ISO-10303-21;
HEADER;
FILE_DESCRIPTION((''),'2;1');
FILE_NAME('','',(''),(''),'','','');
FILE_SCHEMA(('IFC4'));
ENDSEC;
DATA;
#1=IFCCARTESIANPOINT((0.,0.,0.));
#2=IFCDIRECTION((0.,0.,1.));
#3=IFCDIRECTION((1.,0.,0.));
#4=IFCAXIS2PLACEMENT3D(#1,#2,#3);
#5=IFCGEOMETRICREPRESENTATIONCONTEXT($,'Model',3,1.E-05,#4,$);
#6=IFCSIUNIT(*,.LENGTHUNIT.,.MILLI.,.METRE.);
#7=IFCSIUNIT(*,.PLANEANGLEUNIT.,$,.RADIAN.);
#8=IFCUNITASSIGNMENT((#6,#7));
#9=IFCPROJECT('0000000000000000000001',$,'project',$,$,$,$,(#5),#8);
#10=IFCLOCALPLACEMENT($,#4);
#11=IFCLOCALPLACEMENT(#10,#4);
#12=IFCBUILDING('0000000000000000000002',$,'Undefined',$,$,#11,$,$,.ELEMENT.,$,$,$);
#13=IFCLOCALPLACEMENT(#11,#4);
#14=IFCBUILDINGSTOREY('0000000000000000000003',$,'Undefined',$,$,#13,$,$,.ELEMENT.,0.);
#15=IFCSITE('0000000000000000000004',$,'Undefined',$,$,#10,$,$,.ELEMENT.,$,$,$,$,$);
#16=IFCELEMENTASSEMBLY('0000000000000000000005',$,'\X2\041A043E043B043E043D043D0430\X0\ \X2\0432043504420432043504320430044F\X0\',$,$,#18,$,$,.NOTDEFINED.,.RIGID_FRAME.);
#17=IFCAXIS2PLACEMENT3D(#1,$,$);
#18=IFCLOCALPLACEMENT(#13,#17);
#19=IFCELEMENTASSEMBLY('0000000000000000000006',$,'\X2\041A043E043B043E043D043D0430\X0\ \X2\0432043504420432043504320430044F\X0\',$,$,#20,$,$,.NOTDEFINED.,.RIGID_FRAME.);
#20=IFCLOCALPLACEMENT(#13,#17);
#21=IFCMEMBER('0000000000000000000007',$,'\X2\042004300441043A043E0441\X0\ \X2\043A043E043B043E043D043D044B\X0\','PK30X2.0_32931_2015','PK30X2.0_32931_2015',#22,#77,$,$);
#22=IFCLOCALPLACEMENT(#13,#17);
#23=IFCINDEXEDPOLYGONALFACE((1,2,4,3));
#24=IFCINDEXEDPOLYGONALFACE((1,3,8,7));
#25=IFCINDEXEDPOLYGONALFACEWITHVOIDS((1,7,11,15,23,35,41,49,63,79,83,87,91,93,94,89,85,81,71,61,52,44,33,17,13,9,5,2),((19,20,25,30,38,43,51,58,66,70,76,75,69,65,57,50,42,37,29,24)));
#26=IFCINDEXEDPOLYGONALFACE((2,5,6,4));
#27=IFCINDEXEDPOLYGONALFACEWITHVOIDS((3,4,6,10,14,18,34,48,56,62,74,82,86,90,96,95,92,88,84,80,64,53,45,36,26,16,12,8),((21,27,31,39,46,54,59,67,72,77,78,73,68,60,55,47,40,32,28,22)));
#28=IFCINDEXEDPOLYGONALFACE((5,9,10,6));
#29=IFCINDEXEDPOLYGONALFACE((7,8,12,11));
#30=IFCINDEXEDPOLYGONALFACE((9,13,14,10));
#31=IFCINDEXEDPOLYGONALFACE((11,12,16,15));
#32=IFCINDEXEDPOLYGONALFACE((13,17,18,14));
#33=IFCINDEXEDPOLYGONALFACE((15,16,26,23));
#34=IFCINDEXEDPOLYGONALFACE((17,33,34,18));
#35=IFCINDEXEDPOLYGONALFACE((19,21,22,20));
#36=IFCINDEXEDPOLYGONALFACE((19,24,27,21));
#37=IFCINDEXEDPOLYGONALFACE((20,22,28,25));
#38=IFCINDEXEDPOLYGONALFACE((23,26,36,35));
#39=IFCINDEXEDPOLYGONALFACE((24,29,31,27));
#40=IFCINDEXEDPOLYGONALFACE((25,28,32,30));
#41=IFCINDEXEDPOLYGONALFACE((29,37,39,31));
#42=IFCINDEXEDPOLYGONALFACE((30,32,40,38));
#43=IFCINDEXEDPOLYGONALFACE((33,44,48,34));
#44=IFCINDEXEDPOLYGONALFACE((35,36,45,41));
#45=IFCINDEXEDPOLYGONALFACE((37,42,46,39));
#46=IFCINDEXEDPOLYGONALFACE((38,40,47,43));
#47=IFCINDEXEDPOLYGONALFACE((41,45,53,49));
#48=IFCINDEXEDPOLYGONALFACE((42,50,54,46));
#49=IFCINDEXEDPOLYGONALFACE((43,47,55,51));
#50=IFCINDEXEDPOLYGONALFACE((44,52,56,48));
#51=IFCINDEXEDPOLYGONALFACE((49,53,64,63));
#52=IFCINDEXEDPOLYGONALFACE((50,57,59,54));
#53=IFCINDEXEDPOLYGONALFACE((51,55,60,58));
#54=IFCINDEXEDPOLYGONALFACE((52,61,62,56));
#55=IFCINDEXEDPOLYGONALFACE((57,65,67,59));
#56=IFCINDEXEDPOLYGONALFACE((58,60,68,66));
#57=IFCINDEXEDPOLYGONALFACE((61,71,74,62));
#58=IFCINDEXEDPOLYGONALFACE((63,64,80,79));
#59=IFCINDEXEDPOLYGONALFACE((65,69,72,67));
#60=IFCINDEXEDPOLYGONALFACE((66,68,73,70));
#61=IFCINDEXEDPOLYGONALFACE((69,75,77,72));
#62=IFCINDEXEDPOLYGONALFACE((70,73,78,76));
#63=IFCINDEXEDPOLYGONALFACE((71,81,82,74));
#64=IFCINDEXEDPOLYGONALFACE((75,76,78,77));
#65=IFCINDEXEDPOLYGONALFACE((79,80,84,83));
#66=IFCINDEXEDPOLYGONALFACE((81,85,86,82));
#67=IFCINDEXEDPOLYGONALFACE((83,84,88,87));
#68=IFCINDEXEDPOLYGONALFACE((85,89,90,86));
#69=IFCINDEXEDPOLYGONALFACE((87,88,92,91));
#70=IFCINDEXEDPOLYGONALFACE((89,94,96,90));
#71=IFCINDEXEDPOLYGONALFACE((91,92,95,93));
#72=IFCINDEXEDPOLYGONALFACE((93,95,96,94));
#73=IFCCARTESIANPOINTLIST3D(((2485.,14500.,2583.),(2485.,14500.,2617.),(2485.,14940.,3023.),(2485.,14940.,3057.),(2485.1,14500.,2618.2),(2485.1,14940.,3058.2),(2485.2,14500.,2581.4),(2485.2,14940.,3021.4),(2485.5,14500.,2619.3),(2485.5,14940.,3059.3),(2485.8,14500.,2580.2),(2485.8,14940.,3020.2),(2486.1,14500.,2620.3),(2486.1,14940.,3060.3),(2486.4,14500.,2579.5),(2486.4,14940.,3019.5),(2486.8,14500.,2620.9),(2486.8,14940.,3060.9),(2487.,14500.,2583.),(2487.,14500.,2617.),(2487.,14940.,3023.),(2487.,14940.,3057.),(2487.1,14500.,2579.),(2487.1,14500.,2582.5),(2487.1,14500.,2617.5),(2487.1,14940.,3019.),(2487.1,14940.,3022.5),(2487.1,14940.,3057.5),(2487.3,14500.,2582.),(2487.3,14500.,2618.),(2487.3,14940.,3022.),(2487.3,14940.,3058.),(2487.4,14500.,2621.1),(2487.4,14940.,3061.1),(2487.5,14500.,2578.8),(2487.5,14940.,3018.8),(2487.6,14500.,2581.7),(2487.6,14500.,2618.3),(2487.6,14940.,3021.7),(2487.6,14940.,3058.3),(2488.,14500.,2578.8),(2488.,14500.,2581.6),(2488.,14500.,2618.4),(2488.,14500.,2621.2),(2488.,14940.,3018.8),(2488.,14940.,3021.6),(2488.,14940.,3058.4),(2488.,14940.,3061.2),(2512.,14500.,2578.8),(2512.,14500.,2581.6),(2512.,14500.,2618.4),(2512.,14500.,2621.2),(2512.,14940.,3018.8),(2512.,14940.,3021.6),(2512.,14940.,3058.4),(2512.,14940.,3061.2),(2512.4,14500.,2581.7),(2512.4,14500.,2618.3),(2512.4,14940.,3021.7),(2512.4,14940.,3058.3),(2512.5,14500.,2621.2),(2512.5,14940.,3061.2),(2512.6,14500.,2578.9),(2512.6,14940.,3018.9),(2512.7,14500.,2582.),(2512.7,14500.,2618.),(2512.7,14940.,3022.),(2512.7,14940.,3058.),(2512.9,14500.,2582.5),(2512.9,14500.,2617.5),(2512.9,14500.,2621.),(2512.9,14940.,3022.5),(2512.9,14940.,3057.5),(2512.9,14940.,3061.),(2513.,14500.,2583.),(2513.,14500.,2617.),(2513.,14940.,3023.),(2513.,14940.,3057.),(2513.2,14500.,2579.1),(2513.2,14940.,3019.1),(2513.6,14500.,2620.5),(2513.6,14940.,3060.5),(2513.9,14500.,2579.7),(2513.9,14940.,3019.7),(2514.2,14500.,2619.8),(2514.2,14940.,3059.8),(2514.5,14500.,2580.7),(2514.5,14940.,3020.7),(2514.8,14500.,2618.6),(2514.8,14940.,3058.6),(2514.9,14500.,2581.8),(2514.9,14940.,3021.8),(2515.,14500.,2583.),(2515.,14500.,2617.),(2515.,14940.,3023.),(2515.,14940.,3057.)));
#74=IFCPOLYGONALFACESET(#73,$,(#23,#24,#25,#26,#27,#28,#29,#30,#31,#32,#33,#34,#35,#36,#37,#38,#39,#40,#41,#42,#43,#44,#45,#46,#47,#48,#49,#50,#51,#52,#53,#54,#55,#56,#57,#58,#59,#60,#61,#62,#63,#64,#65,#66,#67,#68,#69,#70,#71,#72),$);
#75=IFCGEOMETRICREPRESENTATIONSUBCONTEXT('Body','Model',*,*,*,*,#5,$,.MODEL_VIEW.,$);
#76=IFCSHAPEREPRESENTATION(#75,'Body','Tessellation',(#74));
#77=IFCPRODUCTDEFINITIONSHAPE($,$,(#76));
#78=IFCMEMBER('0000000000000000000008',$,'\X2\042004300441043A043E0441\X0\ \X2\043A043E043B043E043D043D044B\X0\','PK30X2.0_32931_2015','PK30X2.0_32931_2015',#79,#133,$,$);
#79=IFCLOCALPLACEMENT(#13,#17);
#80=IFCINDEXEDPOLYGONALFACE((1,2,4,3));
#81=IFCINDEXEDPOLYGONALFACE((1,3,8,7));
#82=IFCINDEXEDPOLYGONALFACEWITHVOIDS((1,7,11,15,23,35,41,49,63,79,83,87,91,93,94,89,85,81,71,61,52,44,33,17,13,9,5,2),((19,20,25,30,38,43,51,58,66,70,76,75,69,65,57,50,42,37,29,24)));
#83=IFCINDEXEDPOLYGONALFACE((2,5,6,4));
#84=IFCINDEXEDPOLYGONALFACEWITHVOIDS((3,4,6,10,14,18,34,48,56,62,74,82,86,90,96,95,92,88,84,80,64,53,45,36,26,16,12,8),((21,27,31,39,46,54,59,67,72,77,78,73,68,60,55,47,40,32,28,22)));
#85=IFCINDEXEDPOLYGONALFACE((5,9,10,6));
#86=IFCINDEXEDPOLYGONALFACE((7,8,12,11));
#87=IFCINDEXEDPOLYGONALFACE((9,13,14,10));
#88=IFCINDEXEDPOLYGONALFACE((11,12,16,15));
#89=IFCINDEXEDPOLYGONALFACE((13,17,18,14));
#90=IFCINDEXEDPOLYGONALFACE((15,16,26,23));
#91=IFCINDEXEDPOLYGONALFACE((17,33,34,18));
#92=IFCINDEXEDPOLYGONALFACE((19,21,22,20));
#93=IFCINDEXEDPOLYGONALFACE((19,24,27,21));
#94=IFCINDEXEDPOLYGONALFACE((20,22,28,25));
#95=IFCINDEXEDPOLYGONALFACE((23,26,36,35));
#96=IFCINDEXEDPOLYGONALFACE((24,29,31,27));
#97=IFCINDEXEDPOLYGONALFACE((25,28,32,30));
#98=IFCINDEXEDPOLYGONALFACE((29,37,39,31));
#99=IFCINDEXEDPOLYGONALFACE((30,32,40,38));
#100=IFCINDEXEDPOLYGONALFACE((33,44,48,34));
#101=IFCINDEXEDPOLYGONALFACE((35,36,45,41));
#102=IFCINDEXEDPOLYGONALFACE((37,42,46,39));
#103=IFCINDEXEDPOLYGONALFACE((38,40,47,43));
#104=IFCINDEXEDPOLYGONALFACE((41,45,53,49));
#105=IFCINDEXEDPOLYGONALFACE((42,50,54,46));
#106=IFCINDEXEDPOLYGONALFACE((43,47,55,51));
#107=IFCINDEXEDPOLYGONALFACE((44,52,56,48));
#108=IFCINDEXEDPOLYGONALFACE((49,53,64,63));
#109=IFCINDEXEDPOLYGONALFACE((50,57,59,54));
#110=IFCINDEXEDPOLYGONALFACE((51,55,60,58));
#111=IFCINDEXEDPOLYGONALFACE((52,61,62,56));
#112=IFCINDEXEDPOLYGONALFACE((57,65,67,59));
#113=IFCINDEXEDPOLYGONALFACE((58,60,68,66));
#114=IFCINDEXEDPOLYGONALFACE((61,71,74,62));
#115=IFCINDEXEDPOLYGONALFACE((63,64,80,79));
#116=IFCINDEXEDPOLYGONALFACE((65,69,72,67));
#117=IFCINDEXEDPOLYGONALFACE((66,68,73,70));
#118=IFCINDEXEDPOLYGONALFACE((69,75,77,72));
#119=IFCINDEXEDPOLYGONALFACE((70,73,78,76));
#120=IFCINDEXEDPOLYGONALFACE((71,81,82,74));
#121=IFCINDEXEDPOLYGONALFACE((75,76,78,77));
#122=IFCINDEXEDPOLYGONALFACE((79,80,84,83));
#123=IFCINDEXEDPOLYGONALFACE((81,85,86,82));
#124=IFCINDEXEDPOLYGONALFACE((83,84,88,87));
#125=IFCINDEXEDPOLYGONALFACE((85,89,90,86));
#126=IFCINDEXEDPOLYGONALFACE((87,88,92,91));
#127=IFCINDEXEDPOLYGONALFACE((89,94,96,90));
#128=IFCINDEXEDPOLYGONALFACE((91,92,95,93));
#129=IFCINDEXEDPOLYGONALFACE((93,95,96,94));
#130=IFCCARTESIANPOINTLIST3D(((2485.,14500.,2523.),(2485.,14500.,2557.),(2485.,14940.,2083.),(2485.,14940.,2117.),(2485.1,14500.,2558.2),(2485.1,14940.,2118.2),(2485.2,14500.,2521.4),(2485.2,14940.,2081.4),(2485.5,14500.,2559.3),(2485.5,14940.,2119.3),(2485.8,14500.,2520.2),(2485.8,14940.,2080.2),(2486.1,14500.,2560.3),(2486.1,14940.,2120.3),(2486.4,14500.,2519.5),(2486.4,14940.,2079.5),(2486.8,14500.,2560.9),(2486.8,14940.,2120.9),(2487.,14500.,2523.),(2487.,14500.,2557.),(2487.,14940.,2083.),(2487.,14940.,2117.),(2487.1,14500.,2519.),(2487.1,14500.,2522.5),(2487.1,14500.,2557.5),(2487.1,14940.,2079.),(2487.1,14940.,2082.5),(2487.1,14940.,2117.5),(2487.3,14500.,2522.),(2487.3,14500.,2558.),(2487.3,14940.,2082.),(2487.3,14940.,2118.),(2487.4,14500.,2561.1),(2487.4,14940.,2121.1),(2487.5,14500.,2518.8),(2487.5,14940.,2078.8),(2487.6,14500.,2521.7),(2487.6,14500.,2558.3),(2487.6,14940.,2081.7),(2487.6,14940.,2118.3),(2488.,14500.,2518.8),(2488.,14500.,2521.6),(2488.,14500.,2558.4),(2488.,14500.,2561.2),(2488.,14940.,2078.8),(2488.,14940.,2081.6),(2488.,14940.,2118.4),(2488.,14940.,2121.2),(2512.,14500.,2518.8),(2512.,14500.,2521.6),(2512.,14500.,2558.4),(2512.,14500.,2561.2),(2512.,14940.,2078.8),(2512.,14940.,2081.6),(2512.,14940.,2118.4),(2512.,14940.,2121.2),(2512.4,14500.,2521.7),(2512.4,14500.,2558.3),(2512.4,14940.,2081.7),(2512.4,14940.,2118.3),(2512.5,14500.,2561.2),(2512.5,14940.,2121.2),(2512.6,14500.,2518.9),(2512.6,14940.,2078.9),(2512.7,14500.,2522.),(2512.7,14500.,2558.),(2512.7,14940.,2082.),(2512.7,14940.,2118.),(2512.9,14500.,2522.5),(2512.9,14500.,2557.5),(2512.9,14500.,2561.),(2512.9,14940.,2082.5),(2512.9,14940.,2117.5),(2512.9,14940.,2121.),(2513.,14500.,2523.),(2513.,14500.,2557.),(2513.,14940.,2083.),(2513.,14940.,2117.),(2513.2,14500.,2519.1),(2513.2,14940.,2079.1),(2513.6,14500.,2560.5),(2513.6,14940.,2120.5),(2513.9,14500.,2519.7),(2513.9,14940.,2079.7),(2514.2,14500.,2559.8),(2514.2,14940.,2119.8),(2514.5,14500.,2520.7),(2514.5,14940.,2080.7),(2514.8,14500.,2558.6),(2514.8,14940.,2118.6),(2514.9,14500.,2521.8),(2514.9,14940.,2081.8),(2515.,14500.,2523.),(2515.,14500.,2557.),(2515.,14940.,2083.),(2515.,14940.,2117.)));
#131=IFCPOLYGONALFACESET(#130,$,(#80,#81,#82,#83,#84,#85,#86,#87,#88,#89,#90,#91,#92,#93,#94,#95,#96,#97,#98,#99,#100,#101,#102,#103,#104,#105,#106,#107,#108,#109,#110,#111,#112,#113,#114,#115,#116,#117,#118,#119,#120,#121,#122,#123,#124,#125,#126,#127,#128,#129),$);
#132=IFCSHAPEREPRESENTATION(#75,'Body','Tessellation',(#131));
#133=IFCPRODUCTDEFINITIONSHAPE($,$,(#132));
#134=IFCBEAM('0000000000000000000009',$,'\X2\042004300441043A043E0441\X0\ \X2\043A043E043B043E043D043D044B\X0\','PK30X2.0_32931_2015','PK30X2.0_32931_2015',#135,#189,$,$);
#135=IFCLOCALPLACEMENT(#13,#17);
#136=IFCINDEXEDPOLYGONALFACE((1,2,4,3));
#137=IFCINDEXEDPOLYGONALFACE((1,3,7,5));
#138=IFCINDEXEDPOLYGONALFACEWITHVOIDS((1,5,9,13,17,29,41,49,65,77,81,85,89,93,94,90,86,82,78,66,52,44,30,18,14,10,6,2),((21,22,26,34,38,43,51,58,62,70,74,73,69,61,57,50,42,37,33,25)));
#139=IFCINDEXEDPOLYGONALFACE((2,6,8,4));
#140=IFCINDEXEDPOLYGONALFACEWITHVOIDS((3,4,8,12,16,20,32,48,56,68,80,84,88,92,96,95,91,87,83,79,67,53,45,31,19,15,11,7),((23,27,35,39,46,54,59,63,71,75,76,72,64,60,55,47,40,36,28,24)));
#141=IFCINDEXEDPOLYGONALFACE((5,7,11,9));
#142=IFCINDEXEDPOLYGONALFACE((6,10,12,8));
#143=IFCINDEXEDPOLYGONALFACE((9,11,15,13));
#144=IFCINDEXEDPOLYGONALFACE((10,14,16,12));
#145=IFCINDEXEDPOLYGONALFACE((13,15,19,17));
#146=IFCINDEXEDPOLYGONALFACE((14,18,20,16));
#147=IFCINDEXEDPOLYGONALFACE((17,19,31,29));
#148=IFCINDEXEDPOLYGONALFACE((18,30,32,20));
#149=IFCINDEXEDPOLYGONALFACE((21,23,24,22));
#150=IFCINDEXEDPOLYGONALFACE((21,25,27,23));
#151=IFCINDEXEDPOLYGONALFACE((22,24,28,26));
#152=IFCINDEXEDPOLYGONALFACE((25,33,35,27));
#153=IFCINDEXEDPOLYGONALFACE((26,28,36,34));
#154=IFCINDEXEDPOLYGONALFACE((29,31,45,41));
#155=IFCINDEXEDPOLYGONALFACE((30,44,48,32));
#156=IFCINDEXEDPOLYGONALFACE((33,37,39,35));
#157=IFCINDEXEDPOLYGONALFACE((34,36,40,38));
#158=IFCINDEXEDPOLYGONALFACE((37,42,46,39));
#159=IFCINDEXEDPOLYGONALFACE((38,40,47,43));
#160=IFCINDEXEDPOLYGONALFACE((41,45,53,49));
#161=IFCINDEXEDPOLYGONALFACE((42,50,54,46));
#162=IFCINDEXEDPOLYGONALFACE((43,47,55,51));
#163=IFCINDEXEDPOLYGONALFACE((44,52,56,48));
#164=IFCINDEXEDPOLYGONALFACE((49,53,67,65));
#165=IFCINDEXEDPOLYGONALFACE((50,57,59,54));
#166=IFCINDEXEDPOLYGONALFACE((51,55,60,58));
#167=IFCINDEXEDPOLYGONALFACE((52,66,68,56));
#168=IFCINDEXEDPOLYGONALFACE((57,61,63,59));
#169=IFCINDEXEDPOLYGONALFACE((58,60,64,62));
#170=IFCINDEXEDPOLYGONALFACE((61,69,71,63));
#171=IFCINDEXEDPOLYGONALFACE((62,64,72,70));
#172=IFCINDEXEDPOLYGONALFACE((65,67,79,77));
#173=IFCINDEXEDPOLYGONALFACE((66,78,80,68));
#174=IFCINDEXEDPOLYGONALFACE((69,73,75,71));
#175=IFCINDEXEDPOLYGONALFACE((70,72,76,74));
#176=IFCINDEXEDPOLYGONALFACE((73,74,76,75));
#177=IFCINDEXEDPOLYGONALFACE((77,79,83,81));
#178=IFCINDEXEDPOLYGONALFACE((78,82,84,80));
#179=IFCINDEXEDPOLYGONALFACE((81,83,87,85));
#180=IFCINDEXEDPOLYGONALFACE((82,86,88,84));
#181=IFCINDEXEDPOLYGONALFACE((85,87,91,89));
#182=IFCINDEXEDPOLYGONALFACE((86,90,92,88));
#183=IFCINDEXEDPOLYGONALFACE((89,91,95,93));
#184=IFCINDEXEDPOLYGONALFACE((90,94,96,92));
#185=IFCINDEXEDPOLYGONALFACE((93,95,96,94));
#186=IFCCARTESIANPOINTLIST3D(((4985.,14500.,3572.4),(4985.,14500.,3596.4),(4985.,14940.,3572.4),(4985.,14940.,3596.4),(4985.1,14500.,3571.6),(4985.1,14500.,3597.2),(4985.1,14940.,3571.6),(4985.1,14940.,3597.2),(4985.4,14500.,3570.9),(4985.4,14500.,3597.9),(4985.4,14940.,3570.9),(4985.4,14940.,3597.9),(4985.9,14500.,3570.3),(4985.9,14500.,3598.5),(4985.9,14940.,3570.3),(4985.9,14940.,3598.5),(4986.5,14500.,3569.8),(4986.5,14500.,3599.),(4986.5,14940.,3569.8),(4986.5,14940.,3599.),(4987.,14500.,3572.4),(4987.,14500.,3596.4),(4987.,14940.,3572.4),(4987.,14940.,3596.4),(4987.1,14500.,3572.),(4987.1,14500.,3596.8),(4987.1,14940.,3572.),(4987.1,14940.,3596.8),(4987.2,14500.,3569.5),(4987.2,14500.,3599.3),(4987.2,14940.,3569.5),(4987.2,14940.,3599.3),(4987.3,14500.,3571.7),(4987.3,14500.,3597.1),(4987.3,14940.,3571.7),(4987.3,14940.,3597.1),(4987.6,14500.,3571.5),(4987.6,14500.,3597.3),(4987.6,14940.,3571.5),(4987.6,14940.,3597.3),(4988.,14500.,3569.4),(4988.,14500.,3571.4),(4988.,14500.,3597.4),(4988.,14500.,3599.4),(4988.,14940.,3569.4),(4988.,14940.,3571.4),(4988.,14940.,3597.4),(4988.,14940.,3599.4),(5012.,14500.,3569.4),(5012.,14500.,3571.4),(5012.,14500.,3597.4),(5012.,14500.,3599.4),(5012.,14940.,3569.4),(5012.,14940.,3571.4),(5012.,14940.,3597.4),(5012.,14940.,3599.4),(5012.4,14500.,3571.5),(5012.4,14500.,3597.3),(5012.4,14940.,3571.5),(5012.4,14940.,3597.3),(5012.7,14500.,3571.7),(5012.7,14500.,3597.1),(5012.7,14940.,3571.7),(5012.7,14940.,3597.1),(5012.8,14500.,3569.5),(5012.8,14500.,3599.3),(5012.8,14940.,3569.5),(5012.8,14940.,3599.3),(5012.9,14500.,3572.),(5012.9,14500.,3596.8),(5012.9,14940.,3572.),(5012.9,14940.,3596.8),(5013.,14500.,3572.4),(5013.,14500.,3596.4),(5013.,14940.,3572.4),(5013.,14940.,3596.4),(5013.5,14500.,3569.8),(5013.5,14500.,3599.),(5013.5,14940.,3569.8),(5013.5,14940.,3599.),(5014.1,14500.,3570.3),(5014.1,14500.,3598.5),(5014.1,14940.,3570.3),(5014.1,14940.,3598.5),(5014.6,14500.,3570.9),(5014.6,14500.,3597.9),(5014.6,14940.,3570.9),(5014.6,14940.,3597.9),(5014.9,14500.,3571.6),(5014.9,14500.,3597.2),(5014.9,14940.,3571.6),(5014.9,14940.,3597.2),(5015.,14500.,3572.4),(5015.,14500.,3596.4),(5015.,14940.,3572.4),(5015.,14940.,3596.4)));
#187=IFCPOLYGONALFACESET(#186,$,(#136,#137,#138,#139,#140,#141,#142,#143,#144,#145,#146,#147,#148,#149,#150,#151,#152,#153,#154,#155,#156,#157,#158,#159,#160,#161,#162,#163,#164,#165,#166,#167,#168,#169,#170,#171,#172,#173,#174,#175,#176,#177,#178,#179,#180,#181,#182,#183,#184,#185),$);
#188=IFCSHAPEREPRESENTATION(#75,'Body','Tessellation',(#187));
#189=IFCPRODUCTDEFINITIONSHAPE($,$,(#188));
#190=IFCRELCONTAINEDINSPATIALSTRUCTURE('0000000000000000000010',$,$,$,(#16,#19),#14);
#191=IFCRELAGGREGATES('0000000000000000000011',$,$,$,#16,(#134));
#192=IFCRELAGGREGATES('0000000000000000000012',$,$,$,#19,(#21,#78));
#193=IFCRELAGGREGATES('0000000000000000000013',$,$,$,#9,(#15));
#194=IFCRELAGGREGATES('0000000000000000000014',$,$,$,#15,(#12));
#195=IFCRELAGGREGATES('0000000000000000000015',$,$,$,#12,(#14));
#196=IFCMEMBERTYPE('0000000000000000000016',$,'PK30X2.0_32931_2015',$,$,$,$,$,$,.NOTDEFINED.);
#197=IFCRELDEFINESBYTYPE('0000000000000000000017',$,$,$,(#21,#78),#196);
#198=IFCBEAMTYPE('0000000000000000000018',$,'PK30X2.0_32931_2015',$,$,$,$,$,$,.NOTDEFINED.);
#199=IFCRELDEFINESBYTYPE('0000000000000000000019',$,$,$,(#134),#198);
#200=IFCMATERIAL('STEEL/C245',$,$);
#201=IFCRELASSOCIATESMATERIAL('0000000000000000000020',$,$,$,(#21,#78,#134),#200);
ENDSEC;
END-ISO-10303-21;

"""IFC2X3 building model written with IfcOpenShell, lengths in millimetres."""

from ifc_helpers import new_model, si_unit, frame, origin_with_axes, origin_2d_with_axis, place, context, subcontext, project, spatial, hollow_rectangle, extrude, clip, halfspace, material, type_object, element, aggregate, save


model = new_model("IFC2X3")

# Units and contexts
model_context = context("Model", 3, precision=1e-05, world=origin_with_axes())
body_context = subcontext(model_context, "Body", "Model", "MODEL_VIEW")
ifc_project = project(units=[si_unit("LENGTHUNIT", "METRE", prefix="MILLI"), si_unit("PLANEANGLEUNIT", "RADIAN")], contexts=[model_context])

# Site, building, storey
site_placement = place(None, origin_with_axes())
site = spatial("IfcSite", under=ifc_project, at=site_placement, Name="Undefined", CompositionType="ELEMENT")
building_placement = place(site_placement, origin_with_axes())
building = spatial("IfcBuilding", under=site, at=building_placement, Name="Undefined", CompositionType="ELEMENT")
storey_placement = place(building_placement, origin_with_axes())
storey = spatial("IfcBuildingStorey", under=building, at=storey_placement, Name="Undefined", CompositionType="ELEMENT", Elevation=0.0)

# Shared definitions
ifc_material_1 = material(Name="STEEL/C245")

# Element assemblies, members
assembly_1_placement = place(storey_placement, origin_with_axes())
assembly_1 = element("IfcElementAssembly", 1, at=assembly_1_placement, inside=storey, Name="Колонна ветвевая", AssemblyPlace="NOTDEFINED", PredefinedType="RIGID_FRAME")
member_type_1 = type_object("IfcMemberType", Name="PK30X2.0_32931_2015", PredefinedType="NOTDEFINED")
assembly_2_placement = place(storey_placement, origin_with_axes())
assembly_2 = element("IfcElementAssembly", 2, at=assembly_2_placement, inside=storey, Name="Колонна ветвевая", AssemblyPlace="NOTDEFINED", PredefinedType="RIGID_FRAME")
member_1_placement = place(assembly_2_placement, frame((2500.0, 14470.0, 2570.0), z_axis=(0.0, -0.707107, 0.707107), x_axis=(0.0, 0.707107, 0.707107)))
member_1 = element("IfcMember", 3, at=member_1_placement, type_object=member_type_1, material=ifc_material_1, Name="Раскос колонны", Description="PK30X2.0_32931_2015", ObjectType="PK30X2.0_32931_2015", context=body_context, shape_type="Clipping", body=[
    clip(clip(extrude(hollow_rectangle(XDim=30.0, YDim=30.0, WallThickness=2.0, InnerFilletRadius=1.0, OuterFilletRadius=3.0, at=origin_2d_with_axis()), frame((695.0, 0.0, 0.0), z_axis=(-1.0, 0.0, 0.0), x_axis=(0.0, -1.0, 0.0)), (0.0, 0.0, 1.0), 682.9), halfspace(frame((629.0, 0.0, -35.7), z_axis=(-0.707107, 0.0, 0.707107), x_axis=(0.707107, 0.0, 0.707107)), True)), halfspace(frame((65.2, 0.0, 22.8), z_axis=(-0.707107, 0.0, 0.707107), x_axis=(0.707107, 0.0, 0.707107)), False)),
])
member_2_placement = place(assembly_2_placement, frame((2500.0, 14470.0, 2570.0), z_axis=(0.0, -0.707107, -0.707107), x_axis=(0.0, 0.707107, -0.707107)))
member_2 = element("IfcMember", 4, at=member_2_placement, type_object=member_type_1, material=ifc_material_1, Name="Раскос колонны", Description="PK30X2.0_32931_2015", ObjectType="PK30X2.0_32931_2015", context=body_context, shape_type="Clipping", body=[
    clip(clip(extrude(hollow_rectangle(XDim=30.0, YDim=30.0, WallThickness=2.0, InnerFilletRadius=1.0, OuterFilletRadius=3.0, at=origin_2d_with_axis()), frame((695.0, 0.0, 0.0), z_axis=(-1.0, 0.0, 0.0), x_axis=(0.0, -1.0, 0.0)), (0.0, 0.0, 1.0), 682.9), halfspace(frame((629.0, 0.0, -35.7), z_axis=(-0.707107, 0.0, 0.707107), x_axis=(0.707107, 0.0, 0.707107)), True)), halfspace(frame((65.2, 0.0, 22.8), z_axis=(-0.707107, 0.0, 0.707107), x_axis=(0.707107, 0.0, 0.707107)), False)),
])

# Beam
beam_type_1 = type_object("IfcBeamType", Name="PK30X2.0_32931_2015", PredefinedType="NOTDEFINED")
beam_1_placement = place(assembly_1_placement, frame((5000.0, 14500.0, 3584.4), z_axis=(0.0, 0.0, -1.0), x_axis=(0.0, 1.0, 0.0)))
beam_1 = element("IfcBeam", 5, at=beam_1_placement, type_object=beam_type_1, material=ifc_material_1, Name="Раскос колонны", Description="PK30X2.0_32931_2015", ObjectType="PK30X2.0_32931_2015", context=body_context, shape_type="SweptSolid", body=[
    extrude(hollow_rectangle(XDim=30.0, YDim=30.0, WallThickness=2.0, InnerFilletRadius=1.0, OuterFilletRadius=3.0, at=origin_2d_with_axis()), frame((440.0, 0.0, 0.0), z_axis=(-1.0, 0.0, 0.0), x_axis=(0.0, -1.0, 0.0)), (0.0, 0.0, 1.0), 440.0),
])
aggregate(assembly_1, [beam_1])
aggregate(assembly_2, [member_1, member_2])

save(model, "model.ifc")
